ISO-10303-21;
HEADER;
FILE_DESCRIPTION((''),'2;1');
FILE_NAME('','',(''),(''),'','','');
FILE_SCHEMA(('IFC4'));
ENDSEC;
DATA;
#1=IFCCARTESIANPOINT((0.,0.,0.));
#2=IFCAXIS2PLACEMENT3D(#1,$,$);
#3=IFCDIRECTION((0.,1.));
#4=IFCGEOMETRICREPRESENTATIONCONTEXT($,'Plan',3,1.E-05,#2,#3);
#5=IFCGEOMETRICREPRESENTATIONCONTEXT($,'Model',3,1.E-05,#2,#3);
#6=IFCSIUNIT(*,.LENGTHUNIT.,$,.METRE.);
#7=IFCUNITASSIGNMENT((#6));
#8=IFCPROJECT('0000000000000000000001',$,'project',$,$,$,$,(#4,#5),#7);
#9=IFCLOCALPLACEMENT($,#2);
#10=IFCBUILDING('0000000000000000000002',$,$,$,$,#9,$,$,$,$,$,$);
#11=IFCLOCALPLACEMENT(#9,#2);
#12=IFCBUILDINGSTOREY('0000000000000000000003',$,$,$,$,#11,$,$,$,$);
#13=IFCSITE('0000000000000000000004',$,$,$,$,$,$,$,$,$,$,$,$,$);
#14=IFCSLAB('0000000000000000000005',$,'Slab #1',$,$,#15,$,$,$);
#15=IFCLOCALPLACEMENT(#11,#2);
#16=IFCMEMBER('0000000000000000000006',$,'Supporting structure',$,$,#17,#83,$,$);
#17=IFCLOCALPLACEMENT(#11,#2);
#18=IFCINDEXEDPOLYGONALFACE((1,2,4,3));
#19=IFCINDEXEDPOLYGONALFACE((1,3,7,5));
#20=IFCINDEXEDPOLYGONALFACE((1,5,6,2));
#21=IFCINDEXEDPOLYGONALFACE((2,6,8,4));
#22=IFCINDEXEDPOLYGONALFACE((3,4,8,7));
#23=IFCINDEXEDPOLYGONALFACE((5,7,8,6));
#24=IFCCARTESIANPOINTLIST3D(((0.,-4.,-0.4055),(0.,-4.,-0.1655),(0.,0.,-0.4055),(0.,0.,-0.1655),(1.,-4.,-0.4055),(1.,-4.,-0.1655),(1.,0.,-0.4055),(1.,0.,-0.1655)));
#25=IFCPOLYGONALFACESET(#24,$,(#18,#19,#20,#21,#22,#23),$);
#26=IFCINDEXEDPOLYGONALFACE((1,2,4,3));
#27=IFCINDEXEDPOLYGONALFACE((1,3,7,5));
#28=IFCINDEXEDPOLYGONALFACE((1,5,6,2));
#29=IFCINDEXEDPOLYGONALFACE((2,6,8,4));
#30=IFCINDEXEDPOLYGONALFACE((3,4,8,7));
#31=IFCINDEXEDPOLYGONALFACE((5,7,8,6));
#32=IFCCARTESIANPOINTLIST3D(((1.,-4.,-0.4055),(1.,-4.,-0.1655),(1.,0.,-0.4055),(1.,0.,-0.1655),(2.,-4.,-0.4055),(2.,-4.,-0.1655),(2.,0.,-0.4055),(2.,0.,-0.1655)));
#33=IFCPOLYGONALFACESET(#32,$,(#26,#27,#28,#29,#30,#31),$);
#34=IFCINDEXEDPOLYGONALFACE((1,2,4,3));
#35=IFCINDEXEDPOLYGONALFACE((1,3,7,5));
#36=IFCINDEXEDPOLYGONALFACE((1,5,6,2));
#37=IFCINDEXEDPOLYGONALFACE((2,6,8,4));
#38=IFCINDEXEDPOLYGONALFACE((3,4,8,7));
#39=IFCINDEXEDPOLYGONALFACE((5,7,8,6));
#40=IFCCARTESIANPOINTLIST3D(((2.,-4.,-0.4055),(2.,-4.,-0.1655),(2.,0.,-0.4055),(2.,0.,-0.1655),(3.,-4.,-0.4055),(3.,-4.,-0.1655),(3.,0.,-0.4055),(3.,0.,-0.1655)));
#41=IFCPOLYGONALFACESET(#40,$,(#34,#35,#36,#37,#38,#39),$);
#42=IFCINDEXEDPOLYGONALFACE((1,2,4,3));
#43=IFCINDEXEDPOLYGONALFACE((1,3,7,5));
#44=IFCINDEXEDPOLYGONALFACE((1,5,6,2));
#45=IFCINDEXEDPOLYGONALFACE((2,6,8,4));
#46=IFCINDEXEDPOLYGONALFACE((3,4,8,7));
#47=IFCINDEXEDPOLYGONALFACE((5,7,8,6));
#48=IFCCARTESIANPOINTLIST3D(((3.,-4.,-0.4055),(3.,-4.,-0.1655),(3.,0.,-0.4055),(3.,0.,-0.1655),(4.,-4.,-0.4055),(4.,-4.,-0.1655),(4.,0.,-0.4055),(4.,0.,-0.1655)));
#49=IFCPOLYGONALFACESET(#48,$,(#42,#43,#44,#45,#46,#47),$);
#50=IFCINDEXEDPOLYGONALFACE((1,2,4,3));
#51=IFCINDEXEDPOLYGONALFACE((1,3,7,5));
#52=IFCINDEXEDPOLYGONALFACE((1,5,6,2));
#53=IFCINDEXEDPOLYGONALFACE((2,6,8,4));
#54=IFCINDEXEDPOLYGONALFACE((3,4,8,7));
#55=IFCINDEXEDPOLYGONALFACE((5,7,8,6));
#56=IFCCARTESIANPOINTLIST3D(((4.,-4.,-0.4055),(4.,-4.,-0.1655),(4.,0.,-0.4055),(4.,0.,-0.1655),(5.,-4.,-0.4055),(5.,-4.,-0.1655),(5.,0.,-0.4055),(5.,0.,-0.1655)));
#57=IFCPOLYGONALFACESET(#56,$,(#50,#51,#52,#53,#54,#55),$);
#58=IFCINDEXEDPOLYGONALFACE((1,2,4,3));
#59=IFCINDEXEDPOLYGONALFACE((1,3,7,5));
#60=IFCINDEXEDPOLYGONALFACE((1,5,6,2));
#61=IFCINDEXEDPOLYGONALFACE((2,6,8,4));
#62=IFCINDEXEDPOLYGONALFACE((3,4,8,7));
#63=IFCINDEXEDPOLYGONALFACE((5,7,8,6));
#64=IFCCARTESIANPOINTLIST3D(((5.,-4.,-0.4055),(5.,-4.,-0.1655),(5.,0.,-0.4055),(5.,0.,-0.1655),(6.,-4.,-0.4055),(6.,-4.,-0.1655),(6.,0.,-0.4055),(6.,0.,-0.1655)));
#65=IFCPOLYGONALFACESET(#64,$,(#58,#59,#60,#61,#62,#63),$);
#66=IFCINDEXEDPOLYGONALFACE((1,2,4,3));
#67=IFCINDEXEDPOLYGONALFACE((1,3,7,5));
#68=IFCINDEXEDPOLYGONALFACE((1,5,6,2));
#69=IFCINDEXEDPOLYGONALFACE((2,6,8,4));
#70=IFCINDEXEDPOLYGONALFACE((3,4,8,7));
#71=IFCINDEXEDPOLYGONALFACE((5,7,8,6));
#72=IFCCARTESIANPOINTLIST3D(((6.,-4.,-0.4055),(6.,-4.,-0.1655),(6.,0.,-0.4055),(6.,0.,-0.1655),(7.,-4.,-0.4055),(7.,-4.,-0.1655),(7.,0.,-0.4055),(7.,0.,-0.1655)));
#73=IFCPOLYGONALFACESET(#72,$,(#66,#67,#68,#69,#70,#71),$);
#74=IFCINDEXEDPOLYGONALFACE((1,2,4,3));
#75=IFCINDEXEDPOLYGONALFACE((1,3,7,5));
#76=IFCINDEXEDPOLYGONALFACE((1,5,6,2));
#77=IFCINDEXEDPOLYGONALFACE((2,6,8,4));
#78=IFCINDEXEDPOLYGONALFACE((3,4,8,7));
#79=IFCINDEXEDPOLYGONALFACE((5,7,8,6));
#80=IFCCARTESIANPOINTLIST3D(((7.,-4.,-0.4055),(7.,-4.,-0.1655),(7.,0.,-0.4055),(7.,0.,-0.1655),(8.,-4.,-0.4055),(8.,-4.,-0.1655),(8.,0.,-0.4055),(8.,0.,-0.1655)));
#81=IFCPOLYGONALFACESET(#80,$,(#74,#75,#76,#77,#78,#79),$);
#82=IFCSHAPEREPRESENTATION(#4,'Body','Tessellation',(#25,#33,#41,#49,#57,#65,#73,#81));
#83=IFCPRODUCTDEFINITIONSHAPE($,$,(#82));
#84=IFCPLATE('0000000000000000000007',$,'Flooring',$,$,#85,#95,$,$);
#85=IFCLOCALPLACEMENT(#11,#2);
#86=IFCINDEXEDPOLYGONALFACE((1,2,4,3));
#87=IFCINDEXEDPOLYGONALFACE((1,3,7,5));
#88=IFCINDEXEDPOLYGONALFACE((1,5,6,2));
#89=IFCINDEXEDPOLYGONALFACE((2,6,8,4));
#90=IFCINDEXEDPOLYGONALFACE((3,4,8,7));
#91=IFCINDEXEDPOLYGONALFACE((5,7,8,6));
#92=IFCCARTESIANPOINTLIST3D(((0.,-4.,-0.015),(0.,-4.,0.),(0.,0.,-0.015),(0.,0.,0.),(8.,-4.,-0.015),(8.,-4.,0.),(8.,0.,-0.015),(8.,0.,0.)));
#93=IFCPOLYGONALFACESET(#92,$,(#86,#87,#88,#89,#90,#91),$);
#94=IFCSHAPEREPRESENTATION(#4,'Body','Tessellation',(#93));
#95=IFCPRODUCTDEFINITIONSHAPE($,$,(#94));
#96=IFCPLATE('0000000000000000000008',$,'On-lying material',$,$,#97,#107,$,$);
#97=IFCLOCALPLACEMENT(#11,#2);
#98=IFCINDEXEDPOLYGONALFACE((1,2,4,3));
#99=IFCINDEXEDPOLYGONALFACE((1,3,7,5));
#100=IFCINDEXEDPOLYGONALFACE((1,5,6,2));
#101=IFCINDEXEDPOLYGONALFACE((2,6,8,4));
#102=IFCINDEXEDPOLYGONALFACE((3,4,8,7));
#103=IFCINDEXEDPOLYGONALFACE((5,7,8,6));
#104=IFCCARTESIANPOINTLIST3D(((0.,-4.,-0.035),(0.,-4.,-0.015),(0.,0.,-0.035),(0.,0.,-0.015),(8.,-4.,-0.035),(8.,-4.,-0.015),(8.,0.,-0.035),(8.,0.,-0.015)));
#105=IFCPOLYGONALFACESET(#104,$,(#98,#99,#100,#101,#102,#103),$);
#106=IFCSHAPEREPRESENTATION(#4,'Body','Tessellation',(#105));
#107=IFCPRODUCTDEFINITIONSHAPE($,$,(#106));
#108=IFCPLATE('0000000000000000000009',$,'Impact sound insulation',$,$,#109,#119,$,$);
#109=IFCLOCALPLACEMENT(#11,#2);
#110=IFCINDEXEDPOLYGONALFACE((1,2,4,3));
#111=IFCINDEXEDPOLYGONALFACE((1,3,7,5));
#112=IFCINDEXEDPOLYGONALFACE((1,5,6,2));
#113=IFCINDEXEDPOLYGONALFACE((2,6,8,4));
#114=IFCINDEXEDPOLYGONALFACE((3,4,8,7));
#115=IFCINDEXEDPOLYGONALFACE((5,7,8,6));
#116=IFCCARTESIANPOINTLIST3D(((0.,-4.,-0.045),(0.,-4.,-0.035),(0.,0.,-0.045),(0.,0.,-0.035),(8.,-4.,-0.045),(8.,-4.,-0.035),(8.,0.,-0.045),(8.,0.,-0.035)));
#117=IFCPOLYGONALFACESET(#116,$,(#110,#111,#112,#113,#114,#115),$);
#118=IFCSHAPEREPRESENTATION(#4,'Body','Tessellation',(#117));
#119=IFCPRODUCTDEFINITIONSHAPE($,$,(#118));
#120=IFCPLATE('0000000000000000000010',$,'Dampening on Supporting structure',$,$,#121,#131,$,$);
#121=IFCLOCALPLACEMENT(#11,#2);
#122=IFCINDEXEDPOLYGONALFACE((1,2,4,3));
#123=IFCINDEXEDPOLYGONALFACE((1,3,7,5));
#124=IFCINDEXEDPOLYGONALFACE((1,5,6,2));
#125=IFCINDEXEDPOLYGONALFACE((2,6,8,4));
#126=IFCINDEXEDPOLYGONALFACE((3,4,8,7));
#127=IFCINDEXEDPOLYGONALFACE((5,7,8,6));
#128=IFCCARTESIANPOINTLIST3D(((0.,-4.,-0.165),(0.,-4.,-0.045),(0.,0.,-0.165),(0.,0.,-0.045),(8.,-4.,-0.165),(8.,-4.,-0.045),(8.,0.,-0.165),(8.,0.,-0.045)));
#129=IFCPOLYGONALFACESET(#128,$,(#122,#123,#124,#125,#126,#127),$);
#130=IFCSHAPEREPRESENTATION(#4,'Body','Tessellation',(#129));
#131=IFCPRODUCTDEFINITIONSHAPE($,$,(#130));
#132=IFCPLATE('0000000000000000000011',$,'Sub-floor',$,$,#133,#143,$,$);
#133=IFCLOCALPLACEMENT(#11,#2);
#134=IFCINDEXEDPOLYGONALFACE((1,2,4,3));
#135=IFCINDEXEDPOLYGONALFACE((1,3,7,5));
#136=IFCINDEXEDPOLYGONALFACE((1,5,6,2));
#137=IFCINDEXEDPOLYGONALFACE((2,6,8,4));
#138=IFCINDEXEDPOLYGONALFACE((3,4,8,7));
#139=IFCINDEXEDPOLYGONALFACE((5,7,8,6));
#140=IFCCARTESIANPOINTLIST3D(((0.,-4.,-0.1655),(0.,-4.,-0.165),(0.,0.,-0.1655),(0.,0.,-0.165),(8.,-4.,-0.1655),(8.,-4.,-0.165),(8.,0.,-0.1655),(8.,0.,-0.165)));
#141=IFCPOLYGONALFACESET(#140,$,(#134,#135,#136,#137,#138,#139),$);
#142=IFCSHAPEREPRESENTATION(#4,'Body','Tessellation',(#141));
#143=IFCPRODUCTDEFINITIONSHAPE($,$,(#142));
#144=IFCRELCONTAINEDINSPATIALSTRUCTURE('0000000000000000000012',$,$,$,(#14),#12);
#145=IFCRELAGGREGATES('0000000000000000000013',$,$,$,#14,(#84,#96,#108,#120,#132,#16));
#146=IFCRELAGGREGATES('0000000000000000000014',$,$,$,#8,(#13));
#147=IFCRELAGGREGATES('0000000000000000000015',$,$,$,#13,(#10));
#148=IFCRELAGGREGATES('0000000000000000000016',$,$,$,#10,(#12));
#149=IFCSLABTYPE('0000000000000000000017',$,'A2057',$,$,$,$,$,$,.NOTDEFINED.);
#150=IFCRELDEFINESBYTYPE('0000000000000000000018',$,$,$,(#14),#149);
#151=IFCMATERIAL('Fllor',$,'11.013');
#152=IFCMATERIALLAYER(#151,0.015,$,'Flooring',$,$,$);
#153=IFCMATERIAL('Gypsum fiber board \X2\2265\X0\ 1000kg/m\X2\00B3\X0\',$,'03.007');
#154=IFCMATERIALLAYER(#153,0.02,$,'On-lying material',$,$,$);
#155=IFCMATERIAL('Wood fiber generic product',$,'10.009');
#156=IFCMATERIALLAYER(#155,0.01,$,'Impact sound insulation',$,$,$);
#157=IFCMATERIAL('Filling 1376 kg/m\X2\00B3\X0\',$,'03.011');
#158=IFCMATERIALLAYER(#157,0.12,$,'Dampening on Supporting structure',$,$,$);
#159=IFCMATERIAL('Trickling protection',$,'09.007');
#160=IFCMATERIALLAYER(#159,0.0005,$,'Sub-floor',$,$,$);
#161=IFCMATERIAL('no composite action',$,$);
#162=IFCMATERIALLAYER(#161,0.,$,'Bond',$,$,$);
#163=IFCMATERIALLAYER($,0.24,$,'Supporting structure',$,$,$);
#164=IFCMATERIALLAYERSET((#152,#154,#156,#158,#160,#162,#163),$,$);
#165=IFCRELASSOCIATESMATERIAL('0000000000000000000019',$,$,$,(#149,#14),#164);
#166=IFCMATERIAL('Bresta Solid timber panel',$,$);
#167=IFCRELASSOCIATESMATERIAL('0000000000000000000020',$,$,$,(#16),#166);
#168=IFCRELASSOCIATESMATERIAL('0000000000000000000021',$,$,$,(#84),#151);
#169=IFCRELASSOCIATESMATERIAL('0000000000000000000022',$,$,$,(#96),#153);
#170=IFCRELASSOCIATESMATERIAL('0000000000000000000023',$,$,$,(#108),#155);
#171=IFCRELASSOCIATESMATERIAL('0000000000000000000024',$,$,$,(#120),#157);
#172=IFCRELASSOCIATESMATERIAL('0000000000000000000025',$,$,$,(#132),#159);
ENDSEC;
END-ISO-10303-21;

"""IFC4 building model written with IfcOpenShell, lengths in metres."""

from ifc_helpers import new_model, si_unit, direction, frame, frame_2d, origin, origin_with_axes, place, context, project, spatial, rectangle, extrude, material, layer, layer_set, type_object, element, aggregate, save


model = new_model("IFC4")

# Units and contexts
plan_context = context("Plan", 3, precision=1e-05, world=origin(), true_north=direction((0.0, 1.0)))
model_context = context("Model", 3, precision=1e-05, world=origin(), true_north=direction((0.0, 1.0)))
ifc_project = project(units=[si_unit("LENGTHUNIT", "METRE")], contexts=[plan_context, model_context])

# Site, building, storey
site = spatial("IfcSite", under=ifc_project)
building_placement = place(None, origin())
building = spatial("IfcBuilding", under=site, at=building_placement)
storey_placement = place(building_placement, origin())
storey = spatial("IfcBuildingStorey", under=building, at=storey_placement)

# Slab, member, plates
ifc_material_1 = material(Name="Fllor", Category="11.013")
ifc_layer_1 = layer(ifc_material_1, 0.015, Name="Flooring")
ifc_material_2 = material(Name="Gypsum fiber board ≥ 1000kg/m³", Category="03.007")
ifc_layer_2 = layer(ifc_material_2, 0.02, Name="On-lying material")
ifc_material_3 = material(Name="Wood fiber generic product", Category="10.009")
ifc_layer_3 = layer(ifc_material_3, 0.01, Name="Impact sound insulation")
ifc_material_4 = material(Name="Filling 1376 kg/m³", Category="03.011")
ifc_layer_4 = layer(ifc_material_4, 0.12, Name="Dampening on Supporting structure")
ifc_material_5 = material(Name="Trickling protection", Category="09.007")
ifc_layer_5 = layer(ifc_material_5, 0.0005, Name="Sub-floor")
ifc_material_6 = material(Name="no composite action")
ifc_layer_6 = layer(ifc_material_6, 0.0, Name="Bond")
ifc_layer_7 = layer(None, 0.24, Name="Supporting structure")
ifc_layer_set = layer_set([ifc_layer_1, ifc_layer_2, ifc_layer_3, ifc_layer_4, ifc_layer_5, ifc_layer_6, ifc_layer_7])
slab_type = type_object("IfcSlabType", Name="A2057", PredefinedType="NOTDEFINED", material=ifc_layer_set)
slab_placement = place(None, frame((0.0, 0.0, 0.0), z_axis=(0.0, 0.0, -1.0), x_axis=(1.0, 0.0, 0.0)))
slab = element("IfcSlab", 1, at=slab_placement, inside=storey, type_object=slab_type, material=ifc_layer_set, Name="Slab #1")
ifc_material_7 = material(Name="Bresta Solid timber panel")
member_placement = place(slab_placement, origin())
member = element("IfcMember", 2, at=member_placement, material=ifc_material_7, Name="Supporting structure", context=plan_context, shape_type="SweptSolid", body=[
    extrude(rectangle(XDim=1.0, YDim=0.24, at=frame_2d((0.5, 0.12), x_axis=(1.0, 0.0))), frame((0.0, 4.0, 0.1655), z_axis=(0.0, -1.0, 0.0), x_axis=(1.0, 0.0, 0.0)), (0.0, 0.0, 1.0), 4.0),
    extrude(rectangle(XDim=1.0, YDim=0.24, at=frame_2d((0.5, 0.12), x_axis=(1.0, 0.0))), frame((1.0, 4.0, 0.1655), z_axis=(0.0, -1.0, 0.0), x_axis=(1.0, 0.0, 0.0)), (0.0, 0.0, 1.0), 4.0),
    extrude(rectangle(XDim=1.0, YDim=0.24, at=frame_2d((0.5, 0.12), x_axis=(1.0, 0.0))), frame((2.0, 4.0, 0.1655), z_axis=(0.0, -1.0, 0.0), x_axis=(1.0, 0.0, 0.0)), (0.0, 0.0, 1.0), 4.0),
    extrude(rectangle(XDim=1.0, YDim=0.24, at=frame_2d((0.5, 0.12), x_axis=(1.0, 0.0))), frame((3.0, 4.0, 0.1655), z_axis=(0.0, -1.0, 0.0), x_axis=(1.0, 0.0, 0.0)), (0.0, 0.0, 1.0), 4.0),
    extrude(rectangle(XDim=1.0, YDim=0.24, at=frame_2d((0.5, 0.12), x_axis=(1.0, 0.0))), frame((4.0, 4.0, 0.1655), z_axis=(0.0, -1.0, 0.0), x_axis=(1.0, 0.0, 0.0)), (0.0, 0.0, 1.0), 4.0),
    extrude(rectangle(XDim=1.0, YDim=0.24, at=frame_2d((0.5, 0.12), x_axis=(1.0, 0.0))), frame((5.0, 4.0, 0.1655), z_axis=(0.0, -1.0, 0.0), x_axis=(1.0, 0.0, 0.0)), (0.0, 0.0, 1.0), 4.0),
    extrude(rectangle(XDim=1.0, YDim=0.24, at=frame_2d((0.5, 0.12), x_axis=(1.0, 0.0))), frame((6.0, 4.0, 0.1655), z_axis=(0.0, -1.0, 0.0), x_axis=(1.0, 0.0, 0.0)), (0.0, 0.0, 1.0), 4.0),
    extrude(rectangle(XDim=1.0, YDim=0.24, at=frame_2d((0.5, 0.12), x_axis=(1.0, 0.0))), frame((7.0, 4.0, 0.1655), z_axis=(0.0, -1.0, 0.0), x_axis=(1.0, 0.0, 0.0)), (0.0, 0.0, 1.0), 4.0),
])
plate_1_placement = place(slab_placement, origin())
plate_1 = element("IfcPlate", 3, at=plate_1_placement, material=ifc_material_1, Name="Flooring", context=plan_context, shape_type="SweptSolid", body=[
    extrude(rectangle(XDim=8.0, YDim=4.0, at=frame_2d((4.0, 2.0), x_axis=(1.0, 0.0))), origin_with_axes(), (0.0, 0.0, 1.0), 0.015),
])
plate_2_placement = place(slab_placement, origin())
plate_2 = element("IfcPlate", 4, at=plate_2_placement, material=ifc_material_2, Name="On-lying material", context=plan_context, shape_type="SweptSolid", body=[
    extrude(rectangle(XDim=8.0, YDim=4.0, at=frame_2d((4.0, 2.0), x_axis=(1.0, 0.0))), frame((0.0, 0.0, 0.015), z_axis=(0.0, 0.0, 1.0), x_axis=(1.0, 0.0, 0.0)), (0.0, 0.0, 1.0), 0.02),
])
plate_3_placement = place(slab_placement, origin())
plate_3 = element("IfcPlate", 5, at=plate_3_placement, material=ifc_material_3, Name="Impact sound insulation", context=plan_context, shape_type="SweptSolid", body=[
    extrude(rectangle(XDim=8.0, YDim=4.0, at=frame_2d((4.0, 2.0), x_axis=(1.0, 0.0))), frame((0.0, 0.0, 0.035), z_axis=(0.0, 0.0, 1.0), x_axis=(1.0, 0.0, 0.0)), (0.0, 0.0, 1.0), 0.01),
])
plate_4_placement = place(slab_placement, origin())
plate_4 = element("IfcPlate", 6, at=plate_4_placement, material=ifc_material_4, Name="Dampening on Supporting structure", context=plan_context, shape_type="SweptSolid", body=[
    extrude(rectangle(XDim=8.0, YDim=4.0, at=frame_2d((4.0, 2.0), x_axis=(1.0, 0.0))), frame((0.0, 0.0, 0.045), z_axis=(0.0, 0.0, 1.0), x_axis=(1.0, 0.0, 0.0)), (0.0, 0.0, 1.0), 0.12),
])
plate_5_placement = place(slab_placement, origin())
plate_5 = element("IfcPlate", 7, at=plate_5_placement, material=ifc_material_5, Name="Sub-floor", context=plan_context, shape_type="SweptSolid", body=[
    extrude(rectangle(XDim=8.0, YDim=4.0, at=frame_2d((4.0, 2.0), x_axis=(1.0, 0.0))), frame((0.0, 0.0, 0.165), z_axis=(0.0, 0.0, 1.0), x_axis=(1.0, 0.0, 0.0)), (0.0, 0.0, 1.0), 0.0005),
])
aggregate(slab, [plate_1, plate_2, plate_3, plate_4, plate_5, member])

save(model, "model.ifc")
